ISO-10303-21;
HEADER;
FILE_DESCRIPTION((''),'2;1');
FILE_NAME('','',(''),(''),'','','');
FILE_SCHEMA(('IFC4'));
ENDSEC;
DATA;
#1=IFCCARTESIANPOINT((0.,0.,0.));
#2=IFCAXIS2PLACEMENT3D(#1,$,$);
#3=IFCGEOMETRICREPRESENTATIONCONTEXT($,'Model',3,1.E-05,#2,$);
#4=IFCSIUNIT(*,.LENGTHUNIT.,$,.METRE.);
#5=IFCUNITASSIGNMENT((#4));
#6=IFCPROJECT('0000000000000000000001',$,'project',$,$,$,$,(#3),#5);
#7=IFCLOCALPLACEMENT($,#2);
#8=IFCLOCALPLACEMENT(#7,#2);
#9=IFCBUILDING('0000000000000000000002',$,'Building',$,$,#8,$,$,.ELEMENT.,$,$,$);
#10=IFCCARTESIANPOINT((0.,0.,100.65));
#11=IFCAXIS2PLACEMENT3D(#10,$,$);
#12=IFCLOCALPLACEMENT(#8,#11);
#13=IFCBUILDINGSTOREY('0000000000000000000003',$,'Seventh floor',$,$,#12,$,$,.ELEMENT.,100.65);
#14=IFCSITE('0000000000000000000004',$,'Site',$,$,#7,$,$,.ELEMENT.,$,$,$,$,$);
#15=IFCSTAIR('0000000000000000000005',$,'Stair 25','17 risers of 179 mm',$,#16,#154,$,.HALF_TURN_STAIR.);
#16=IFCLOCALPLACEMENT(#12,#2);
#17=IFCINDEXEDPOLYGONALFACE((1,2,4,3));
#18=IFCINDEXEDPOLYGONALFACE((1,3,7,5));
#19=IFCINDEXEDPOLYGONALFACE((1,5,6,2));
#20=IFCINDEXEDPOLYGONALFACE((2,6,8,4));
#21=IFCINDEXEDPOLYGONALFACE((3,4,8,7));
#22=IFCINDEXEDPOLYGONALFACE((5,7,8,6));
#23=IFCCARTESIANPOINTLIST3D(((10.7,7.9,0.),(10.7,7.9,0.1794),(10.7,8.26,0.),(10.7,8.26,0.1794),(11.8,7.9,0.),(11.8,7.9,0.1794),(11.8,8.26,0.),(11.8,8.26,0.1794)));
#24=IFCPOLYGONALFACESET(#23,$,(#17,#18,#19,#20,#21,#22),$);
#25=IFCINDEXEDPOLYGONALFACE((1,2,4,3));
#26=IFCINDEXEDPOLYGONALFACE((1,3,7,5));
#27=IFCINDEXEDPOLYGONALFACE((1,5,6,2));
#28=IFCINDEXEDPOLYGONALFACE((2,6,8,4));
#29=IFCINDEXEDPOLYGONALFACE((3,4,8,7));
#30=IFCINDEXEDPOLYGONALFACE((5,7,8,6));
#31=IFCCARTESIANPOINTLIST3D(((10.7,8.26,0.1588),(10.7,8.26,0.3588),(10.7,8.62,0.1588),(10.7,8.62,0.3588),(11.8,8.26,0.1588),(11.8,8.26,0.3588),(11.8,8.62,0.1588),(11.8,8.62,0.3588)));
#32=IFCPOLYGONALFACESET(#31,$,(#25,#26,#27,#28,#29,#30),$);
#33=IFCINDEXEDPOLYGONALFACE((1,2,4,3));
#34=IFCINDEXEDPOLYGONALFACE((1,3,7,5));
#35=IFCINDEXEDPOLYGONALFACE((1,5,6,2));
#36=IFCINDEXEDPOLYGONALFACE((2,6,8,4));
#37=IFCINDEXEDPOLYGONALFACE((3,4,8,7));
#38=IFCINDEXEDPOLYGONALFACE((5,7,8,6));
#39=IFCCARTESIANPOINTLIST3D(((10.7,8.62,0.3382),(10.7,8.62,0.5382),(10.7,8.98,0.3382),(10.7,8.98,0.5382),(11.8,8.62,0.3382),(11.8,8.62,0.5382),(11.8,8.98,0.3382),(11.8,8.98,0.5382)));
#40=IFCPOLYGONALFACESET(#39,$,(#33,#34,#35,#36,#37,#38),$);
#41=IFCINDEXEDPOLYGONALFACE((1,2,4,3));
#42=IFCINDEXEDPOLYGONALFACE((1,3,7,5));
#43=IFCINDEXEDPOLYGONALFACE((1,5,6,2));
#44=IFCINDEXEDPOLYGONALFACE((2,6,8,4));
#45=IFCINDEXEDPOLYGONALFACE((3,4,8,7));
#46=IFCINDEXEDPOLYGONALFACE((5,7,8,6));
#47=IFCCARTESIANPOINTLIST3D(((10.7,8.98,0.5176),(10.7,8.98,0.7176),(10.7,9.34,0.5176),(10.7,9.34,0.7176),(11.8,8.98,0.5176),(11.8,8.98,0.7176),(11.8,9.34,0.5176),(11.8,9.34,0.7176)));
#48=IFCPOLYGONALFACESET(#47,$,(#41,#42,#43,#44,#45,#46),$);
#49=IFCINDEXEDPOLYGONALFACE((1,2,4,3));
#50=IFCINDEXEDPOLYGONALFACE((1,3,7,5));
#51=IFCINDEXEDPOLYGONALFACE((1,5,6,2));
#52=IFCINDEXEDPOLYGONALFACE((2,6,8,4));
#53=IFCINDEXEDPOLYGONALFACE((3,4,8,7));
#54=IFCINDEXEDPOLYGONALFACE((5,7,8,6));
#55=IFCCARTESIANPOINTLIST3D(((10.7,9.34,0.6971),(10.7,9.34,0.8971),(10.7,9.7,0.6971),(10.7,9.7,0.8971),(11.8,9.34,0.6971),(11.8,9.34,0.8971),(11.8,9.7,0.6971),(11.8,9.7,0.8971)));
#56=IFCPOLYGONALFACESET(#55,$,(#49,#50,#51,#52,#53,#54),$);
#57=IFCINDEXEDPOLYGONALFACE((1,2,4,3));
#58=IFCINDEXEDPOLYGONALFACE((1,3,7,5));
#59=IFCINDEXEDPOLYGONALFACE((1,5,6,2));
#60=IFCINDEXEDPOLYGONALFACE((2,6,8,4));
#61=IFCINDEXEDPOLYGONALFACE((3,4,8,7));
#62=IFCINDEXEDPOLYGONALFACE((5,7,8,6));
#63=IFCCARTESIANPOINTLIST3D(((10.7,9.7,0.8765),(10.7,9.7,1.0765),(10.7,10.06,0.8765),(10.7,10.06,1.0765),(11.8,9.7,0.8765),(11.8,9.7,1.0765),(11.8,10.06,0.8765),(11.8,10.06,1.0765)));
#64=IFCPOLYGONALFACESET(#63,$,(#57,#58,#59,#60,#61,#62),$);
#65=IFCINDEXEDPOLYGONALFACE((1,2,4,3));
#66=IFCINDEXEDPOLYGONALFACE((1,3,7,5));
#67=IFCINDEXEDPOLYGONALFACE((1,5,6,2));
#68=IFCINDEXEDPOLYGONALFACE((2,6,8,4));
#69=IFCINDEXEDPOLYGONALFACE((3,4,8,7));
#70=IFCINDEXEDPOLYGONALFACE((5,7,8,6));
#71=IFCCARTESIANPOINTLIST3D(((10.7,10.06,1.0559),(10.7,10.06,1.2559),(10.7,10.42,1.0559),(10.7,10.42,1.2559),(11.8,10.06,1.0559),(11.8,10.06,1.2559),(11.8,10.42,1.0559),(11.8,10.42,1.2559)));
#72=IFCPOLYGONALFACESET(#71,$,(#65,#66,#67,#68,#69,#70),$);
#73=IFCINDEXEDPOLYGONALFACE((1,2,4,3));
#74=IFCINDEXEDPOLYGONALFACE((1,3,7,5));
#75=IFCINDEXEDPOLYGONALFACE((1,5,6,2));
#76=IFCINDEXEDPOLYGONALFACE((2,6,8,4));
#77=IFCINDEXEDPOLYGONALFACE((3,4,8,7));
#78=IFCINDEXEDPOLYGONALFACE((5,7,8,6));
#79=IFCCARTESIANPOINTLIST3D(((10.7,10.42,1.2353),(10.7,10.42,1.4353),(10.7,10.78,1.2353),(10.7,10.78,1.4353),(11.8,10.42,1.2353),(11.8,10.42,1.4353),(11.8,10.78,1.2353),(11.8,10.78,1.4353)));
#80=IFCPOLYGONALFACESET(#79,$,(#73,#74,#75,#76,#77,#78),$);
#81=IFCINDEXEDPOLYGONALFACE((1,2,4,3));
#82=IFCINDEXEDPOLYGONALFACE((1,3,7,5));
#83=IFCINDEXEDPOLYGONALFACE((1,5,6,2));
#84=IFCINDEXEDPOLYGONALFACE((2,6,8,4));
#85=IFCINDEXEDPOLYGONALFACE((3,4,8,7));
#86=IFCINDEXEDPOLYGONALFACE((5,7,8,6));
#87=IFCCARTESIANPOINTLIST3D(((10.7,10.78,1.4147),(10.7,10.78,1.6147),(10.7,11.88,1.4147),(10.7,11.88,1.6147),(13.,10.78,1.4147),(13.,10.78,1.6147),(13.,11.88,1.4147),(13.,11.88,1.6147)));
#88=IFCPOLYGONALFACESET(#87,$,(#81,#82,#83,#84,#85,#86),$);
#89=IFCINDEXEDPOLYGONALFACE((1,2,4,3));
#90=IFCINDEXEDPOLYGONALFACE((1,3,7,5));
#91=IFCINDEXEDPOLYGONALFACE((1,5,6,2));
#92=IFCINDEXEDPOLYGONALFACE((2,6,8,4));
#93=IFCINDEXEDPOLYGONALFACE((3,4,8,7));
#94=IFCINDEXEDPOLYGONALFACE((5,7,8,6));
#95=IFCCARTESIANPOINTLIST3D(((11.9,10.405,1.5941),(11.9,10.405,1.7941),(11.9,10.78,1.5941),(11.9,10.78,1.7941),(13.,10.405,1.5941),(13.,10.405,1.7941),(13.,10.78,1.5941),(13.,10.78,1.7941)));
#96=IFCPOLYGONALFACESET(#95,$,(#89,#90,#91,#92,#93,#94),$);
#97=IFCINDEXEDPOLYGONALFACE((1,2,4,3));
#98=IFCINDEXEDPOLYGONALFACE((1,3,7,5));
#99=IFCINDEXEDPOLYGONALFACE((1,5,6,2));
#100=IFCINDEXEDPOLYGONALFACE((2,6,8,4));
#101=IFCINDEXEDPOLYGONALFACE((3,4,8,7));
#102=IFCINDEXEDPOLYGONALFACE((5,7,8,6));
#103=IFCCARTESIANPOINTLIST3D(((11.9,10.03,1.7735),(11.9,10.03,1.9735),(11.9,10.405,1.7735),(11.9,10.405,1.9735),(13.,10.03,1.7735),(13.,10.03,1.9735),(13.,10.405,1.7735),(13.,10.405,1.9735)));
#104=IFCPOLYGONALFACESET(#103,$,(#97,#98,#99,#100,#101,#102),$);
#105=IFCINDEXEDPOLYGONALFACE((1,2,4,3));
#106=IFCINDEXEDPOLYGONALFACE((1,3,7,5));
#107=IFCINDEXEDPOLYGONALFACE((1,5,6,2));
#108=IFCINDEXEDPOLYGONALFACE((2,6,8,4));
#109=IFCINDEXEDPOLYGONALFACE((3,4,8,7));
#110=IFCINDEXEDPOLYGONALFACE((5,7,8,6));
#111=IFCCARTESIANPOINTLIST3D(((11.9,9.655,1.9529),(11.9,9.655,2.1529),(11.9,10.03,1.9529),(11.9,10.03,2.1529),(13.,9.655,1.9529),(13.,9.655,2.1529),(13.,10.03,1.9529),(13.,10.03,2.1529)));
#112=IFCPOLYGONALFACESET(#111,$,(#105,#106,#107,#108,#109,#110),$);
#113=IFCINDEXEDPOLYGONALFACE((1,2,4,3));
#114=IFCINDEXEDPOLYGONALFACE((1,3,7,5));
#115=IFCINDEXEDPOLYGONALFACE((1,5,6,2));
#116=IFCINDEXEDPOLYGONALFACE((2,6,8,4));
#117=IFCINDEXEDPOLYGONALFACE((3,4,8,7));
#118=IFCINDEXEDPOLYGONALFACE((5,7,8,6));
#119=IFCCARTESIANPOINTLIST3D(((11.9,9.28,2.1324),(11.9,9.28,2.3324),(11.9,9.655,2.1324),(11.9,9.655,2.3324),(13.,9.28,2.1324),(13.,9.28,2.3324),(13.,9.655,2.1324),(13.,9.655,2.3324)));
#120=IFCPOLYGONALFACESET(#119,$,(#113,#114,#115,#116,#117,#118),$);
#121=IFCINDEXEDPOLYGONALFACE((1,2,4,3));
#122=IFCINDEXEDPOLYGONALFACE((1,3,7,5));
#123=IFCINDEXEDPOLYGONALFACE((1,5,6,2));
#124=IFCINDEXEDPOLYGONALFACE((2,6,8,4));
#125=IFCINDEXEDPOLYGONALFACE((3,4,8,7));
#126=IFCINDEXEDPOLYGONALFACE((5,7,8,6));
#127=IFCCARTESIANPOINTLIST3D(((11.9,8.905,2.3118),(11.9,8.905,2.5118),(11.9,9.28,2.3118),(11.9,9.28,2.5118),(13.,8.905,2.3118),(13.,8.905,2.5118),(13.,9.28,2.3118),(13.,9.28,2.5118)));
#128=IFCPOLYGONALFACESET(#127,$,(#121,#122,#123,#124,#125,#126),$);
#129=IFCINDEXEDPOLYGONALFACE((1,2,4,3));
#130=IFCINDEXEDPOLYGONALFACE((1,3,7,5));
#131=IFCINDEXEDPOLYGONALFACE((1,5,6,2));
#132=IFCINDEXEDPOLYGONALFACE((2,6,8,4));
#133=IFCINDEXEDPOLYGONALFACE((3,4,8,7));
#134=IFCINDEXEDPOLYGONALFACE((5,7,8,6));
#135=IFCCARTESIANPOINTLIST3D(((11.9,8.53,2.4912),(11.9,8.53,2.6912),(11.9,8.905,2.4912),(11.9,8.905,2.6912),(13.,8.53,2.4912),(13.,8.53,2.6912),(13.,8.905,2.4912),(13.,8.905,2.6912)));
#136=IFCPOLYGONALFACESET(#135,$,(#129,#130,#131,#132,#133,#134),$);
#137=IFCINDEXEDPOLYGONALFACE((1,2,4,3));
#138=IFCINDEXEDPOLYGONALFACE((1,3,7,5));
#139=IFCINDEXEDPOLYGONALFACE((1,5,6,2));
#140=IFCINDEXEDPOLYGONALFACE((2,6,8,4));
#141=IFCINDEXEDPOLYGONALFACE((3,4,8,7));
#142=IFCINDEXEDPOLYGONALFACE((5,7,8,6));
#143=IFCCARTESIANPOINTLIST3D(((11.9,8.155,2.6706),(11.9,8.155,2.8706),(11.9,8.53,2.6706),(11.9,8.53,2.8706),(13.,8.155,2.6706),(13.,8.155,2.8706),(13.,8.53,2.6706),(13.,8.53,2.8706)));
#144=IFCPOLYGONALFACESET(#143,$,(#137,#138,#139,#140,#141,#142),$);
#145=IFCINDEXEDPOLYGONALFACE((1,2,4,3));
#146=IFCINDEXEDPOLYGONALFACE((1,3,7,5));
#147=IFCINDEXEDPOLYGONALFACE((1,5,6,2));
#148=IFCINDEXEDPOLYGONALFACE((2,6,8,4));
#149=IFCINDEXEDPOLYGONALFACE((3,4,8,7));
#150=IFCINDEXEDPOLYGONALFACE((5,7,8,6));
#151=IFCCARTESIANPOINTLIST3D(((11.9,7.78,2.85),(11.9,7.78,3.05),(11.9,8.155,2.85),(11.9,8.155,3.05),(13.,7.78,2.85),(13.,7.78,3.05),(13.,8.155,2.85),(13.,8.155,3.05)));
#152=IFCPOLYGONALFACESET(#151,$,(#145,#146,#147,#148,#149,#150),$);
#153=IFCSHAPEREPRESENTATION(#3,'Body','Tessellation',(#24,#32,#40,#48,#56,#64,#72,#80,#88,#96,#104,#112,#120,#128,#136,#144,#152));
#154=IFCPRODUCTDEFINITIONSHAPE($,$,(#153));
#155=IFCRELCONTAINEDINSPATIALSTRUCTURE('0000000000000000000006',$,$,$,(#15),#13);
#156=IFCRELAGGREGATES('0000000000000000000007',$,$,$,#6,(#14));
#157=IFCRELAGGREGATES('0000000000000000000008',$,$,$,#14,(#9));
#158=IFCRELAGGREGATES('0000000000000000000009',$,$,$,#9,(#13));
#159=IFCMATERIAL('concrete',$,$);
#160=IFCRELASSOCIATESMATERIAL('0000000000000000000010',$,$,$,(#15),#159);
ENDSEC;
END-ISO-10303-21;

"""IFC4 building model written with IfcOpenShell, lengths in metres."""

from ifc_helpers import new_model, si_unit, frame, origin, place, context, project, spatial, polyline, outline, extrude, material, element, save


model = new_model("IFC4")

# Units and contexts
model_context = context("Model", 3, precision=1e-05, world=origin())
ifc_project = project(units=[si_unit("LENGTHUNIT", "METRE")], contexts=[model_context])

# Site, building, storey
site_placement = place(None, origin())
site = spatial("IfcSite", under=ifc_project, at=site_placement, Name="Site", CompositionType="ELEMENT")
building_placement = place(site_placement, origin())
building = spatial("IfcBuilding", under=site, at=building_placement, Name="Building", CompositionType="ELEMENT")
storey_placement = place(building_placement, frame((0.0, 0.0, 100.65)))
storey = spatial("IfcBuildingStorey", under=building, at=storey_placement, Name="Seventh floor", CompositionType="ELEMENT", Elevation=100.65)

# Shared definitions
ifc_material = material(Name="concrete")

# Stair
stair_placement = place(storey_placement, frame((11.25, 7.9, 0.0), z_axis=(0.0, 0.0, 1.0), x_axis=(0.0, 1.0, 0.0)))
element("IfcStair", 1, at=stair_placement, inside=storey, material=ifc_material, Name="Stair 25", Description="17 risers of 179 mm", PredefinedType="HALF_TURN_STAIR", context=model_context, shape_type="SweptSolid", body=[
    extrude(outline(polyline([(0.0, -0.55), (0.36, -0.55), (0.36, 0.55), (0.0, 0.55), (0.0, -0.55)])), origin(), (0.0, 0.0, 1.0), 0.1794),
    extrude(outline(polyline([(0.36, -0.55), (0.72, -0.55), (0.72, 0.55), (0.36, 0.55), (0.36, -0.55)])), frame((0.0, 0.0, 0.1588)), (0.0, 0.0, 1.0), 0.2),
    extrude(outline(polyline([(0.72, -0.55), (1.08, -0.55), (1.08, 0.55), (0.72, 0.55), (0.72, -0.55)])), frame((0.0, 0.0, 0.3382)), (0.0, 0.0, 1.0), 0.2),
    extrude(outline(polyline([(1.08, -0.55), (1.44, -0.55), (1.44, 0.55), (1.08, 0.55), (1.08, -0.55)])), frame((0.0, 0.0, 0.5176)), (0.0, 0.0, 1.0), 0.2),
    extrude(outline(polyline([(1.44, -0.55), (1.8, -0.55), (1.8, 0.55), (1.44, 0.55), (1.44, -0.55)])), frame((0.0, 0.0, 0.6971)), (0.0, 0.0, 1.0), 0.2),
    extrude(outline(polyline([(1.8, -0.55), (2.16, -0.55), (2.16, 0.55), (1.8, 0.55), (1.8, -0.55)])), frame((0.0, 0.0, 0.8765)), (0.0, 0.0, 1.0), 0.2),
    extrude(outline(polyline([(2.16, -0.55), (2.52, -0.55), (2.52, 0.55), (2.16, 0.55), (2.16, -0.55)])), frame((0.0, 0.0, 1.0559)), (0.0, 0.0, 1.0), 0.2),
    extrude(outline(polyline([(2.52, -0.55), (2.88, -0.55), (2.88, 0.55), (2.52, 0.55), (2.52, -0.55)])), frame((0.0, 0.0, 1.2353)), (0.0, 0.0, 1.0), 0.2),
    extrude(outline(polyline([(2.88, -1.75), (3.98, -1.75), (3.98, 0.55), (2.88, 0.55), (2.88, -1.75)])), frame((0.0, 0.0, 1.4147)), (0.0, 0.0, 1.0), 0.2),
    extrude(outline(polyline([(2.505, -1.75), (2.88, -1.75), (2.88, -0.65), (2.505, -0.65), (2.505, -1.75)])), frame((0.0, 0.0, 1.5941)), (0.0, 0.0, 1.0), 0.2),
    extrude(outline(polyline([(2.13, -1.75), (2.505, -1.75), (2.505, -0.65), (2.13, -0.65), (2.13, -1.75)])), frame((0.0, 0.0, 1.7735)), (0.0, 0.0, 1.0), 0.2),
    extrude(outline(polyline([(1.755, -1.75), (2.13, -1.75), (2.13, -0.65), (1.755, -0.65), (1.755, -1.75)])), frame((0.0, 0.0, 1.9529)), (0.0, 0.0, 1.0), 0.2),
    extrude(outline(polyline([(1.38, -1.75), (1.755, -1.75), (1.755, -0.65), (1.38, -0.65), (1.38, -1.75)])), frame((0.0, 0.0, 2.1324)), (0.0, 0.0, 1.0), 0.2),
    extrude(outline(polyline([(1.005, -1.75), (1.38, -1.75), (1.38, -0.65), (1.005, -0.65), (1.005, -1.75)])), frame((0.0, 0.0, 2.3118)), (0.0, 0.0, 1.0), 0.2),
    extrude(outline(polyline([(0.63, -1.75), (1.005, -1.75), (1.005, -0.65), (0.63, -0.65), (0.63, -1.75)])), frame((0.0, 0.0, 2.4912)), (0.0, 0.0, 1.0), 0.2),
    extrude(outline(polyline([(0.255, -1.75), (0.63, -1.75), (0.63, -0.65), (0.255, -0.65), (0.255, -1.75)])), frame((0.0, 0.0, 2.6706)), (0.0, 0.0, 1.0), 0.2),
    extrude(outline(polyline([(-0.12, -1.75), (0.255, -1.75), (0.255, -0.65), (-0.12, -0.65), (-0.12, -1.75)])), frame((0.0, 0.0, 2.85)), (0.0, 0.0, 1.0), 0.2),
])

save(model, "model.ifc")
